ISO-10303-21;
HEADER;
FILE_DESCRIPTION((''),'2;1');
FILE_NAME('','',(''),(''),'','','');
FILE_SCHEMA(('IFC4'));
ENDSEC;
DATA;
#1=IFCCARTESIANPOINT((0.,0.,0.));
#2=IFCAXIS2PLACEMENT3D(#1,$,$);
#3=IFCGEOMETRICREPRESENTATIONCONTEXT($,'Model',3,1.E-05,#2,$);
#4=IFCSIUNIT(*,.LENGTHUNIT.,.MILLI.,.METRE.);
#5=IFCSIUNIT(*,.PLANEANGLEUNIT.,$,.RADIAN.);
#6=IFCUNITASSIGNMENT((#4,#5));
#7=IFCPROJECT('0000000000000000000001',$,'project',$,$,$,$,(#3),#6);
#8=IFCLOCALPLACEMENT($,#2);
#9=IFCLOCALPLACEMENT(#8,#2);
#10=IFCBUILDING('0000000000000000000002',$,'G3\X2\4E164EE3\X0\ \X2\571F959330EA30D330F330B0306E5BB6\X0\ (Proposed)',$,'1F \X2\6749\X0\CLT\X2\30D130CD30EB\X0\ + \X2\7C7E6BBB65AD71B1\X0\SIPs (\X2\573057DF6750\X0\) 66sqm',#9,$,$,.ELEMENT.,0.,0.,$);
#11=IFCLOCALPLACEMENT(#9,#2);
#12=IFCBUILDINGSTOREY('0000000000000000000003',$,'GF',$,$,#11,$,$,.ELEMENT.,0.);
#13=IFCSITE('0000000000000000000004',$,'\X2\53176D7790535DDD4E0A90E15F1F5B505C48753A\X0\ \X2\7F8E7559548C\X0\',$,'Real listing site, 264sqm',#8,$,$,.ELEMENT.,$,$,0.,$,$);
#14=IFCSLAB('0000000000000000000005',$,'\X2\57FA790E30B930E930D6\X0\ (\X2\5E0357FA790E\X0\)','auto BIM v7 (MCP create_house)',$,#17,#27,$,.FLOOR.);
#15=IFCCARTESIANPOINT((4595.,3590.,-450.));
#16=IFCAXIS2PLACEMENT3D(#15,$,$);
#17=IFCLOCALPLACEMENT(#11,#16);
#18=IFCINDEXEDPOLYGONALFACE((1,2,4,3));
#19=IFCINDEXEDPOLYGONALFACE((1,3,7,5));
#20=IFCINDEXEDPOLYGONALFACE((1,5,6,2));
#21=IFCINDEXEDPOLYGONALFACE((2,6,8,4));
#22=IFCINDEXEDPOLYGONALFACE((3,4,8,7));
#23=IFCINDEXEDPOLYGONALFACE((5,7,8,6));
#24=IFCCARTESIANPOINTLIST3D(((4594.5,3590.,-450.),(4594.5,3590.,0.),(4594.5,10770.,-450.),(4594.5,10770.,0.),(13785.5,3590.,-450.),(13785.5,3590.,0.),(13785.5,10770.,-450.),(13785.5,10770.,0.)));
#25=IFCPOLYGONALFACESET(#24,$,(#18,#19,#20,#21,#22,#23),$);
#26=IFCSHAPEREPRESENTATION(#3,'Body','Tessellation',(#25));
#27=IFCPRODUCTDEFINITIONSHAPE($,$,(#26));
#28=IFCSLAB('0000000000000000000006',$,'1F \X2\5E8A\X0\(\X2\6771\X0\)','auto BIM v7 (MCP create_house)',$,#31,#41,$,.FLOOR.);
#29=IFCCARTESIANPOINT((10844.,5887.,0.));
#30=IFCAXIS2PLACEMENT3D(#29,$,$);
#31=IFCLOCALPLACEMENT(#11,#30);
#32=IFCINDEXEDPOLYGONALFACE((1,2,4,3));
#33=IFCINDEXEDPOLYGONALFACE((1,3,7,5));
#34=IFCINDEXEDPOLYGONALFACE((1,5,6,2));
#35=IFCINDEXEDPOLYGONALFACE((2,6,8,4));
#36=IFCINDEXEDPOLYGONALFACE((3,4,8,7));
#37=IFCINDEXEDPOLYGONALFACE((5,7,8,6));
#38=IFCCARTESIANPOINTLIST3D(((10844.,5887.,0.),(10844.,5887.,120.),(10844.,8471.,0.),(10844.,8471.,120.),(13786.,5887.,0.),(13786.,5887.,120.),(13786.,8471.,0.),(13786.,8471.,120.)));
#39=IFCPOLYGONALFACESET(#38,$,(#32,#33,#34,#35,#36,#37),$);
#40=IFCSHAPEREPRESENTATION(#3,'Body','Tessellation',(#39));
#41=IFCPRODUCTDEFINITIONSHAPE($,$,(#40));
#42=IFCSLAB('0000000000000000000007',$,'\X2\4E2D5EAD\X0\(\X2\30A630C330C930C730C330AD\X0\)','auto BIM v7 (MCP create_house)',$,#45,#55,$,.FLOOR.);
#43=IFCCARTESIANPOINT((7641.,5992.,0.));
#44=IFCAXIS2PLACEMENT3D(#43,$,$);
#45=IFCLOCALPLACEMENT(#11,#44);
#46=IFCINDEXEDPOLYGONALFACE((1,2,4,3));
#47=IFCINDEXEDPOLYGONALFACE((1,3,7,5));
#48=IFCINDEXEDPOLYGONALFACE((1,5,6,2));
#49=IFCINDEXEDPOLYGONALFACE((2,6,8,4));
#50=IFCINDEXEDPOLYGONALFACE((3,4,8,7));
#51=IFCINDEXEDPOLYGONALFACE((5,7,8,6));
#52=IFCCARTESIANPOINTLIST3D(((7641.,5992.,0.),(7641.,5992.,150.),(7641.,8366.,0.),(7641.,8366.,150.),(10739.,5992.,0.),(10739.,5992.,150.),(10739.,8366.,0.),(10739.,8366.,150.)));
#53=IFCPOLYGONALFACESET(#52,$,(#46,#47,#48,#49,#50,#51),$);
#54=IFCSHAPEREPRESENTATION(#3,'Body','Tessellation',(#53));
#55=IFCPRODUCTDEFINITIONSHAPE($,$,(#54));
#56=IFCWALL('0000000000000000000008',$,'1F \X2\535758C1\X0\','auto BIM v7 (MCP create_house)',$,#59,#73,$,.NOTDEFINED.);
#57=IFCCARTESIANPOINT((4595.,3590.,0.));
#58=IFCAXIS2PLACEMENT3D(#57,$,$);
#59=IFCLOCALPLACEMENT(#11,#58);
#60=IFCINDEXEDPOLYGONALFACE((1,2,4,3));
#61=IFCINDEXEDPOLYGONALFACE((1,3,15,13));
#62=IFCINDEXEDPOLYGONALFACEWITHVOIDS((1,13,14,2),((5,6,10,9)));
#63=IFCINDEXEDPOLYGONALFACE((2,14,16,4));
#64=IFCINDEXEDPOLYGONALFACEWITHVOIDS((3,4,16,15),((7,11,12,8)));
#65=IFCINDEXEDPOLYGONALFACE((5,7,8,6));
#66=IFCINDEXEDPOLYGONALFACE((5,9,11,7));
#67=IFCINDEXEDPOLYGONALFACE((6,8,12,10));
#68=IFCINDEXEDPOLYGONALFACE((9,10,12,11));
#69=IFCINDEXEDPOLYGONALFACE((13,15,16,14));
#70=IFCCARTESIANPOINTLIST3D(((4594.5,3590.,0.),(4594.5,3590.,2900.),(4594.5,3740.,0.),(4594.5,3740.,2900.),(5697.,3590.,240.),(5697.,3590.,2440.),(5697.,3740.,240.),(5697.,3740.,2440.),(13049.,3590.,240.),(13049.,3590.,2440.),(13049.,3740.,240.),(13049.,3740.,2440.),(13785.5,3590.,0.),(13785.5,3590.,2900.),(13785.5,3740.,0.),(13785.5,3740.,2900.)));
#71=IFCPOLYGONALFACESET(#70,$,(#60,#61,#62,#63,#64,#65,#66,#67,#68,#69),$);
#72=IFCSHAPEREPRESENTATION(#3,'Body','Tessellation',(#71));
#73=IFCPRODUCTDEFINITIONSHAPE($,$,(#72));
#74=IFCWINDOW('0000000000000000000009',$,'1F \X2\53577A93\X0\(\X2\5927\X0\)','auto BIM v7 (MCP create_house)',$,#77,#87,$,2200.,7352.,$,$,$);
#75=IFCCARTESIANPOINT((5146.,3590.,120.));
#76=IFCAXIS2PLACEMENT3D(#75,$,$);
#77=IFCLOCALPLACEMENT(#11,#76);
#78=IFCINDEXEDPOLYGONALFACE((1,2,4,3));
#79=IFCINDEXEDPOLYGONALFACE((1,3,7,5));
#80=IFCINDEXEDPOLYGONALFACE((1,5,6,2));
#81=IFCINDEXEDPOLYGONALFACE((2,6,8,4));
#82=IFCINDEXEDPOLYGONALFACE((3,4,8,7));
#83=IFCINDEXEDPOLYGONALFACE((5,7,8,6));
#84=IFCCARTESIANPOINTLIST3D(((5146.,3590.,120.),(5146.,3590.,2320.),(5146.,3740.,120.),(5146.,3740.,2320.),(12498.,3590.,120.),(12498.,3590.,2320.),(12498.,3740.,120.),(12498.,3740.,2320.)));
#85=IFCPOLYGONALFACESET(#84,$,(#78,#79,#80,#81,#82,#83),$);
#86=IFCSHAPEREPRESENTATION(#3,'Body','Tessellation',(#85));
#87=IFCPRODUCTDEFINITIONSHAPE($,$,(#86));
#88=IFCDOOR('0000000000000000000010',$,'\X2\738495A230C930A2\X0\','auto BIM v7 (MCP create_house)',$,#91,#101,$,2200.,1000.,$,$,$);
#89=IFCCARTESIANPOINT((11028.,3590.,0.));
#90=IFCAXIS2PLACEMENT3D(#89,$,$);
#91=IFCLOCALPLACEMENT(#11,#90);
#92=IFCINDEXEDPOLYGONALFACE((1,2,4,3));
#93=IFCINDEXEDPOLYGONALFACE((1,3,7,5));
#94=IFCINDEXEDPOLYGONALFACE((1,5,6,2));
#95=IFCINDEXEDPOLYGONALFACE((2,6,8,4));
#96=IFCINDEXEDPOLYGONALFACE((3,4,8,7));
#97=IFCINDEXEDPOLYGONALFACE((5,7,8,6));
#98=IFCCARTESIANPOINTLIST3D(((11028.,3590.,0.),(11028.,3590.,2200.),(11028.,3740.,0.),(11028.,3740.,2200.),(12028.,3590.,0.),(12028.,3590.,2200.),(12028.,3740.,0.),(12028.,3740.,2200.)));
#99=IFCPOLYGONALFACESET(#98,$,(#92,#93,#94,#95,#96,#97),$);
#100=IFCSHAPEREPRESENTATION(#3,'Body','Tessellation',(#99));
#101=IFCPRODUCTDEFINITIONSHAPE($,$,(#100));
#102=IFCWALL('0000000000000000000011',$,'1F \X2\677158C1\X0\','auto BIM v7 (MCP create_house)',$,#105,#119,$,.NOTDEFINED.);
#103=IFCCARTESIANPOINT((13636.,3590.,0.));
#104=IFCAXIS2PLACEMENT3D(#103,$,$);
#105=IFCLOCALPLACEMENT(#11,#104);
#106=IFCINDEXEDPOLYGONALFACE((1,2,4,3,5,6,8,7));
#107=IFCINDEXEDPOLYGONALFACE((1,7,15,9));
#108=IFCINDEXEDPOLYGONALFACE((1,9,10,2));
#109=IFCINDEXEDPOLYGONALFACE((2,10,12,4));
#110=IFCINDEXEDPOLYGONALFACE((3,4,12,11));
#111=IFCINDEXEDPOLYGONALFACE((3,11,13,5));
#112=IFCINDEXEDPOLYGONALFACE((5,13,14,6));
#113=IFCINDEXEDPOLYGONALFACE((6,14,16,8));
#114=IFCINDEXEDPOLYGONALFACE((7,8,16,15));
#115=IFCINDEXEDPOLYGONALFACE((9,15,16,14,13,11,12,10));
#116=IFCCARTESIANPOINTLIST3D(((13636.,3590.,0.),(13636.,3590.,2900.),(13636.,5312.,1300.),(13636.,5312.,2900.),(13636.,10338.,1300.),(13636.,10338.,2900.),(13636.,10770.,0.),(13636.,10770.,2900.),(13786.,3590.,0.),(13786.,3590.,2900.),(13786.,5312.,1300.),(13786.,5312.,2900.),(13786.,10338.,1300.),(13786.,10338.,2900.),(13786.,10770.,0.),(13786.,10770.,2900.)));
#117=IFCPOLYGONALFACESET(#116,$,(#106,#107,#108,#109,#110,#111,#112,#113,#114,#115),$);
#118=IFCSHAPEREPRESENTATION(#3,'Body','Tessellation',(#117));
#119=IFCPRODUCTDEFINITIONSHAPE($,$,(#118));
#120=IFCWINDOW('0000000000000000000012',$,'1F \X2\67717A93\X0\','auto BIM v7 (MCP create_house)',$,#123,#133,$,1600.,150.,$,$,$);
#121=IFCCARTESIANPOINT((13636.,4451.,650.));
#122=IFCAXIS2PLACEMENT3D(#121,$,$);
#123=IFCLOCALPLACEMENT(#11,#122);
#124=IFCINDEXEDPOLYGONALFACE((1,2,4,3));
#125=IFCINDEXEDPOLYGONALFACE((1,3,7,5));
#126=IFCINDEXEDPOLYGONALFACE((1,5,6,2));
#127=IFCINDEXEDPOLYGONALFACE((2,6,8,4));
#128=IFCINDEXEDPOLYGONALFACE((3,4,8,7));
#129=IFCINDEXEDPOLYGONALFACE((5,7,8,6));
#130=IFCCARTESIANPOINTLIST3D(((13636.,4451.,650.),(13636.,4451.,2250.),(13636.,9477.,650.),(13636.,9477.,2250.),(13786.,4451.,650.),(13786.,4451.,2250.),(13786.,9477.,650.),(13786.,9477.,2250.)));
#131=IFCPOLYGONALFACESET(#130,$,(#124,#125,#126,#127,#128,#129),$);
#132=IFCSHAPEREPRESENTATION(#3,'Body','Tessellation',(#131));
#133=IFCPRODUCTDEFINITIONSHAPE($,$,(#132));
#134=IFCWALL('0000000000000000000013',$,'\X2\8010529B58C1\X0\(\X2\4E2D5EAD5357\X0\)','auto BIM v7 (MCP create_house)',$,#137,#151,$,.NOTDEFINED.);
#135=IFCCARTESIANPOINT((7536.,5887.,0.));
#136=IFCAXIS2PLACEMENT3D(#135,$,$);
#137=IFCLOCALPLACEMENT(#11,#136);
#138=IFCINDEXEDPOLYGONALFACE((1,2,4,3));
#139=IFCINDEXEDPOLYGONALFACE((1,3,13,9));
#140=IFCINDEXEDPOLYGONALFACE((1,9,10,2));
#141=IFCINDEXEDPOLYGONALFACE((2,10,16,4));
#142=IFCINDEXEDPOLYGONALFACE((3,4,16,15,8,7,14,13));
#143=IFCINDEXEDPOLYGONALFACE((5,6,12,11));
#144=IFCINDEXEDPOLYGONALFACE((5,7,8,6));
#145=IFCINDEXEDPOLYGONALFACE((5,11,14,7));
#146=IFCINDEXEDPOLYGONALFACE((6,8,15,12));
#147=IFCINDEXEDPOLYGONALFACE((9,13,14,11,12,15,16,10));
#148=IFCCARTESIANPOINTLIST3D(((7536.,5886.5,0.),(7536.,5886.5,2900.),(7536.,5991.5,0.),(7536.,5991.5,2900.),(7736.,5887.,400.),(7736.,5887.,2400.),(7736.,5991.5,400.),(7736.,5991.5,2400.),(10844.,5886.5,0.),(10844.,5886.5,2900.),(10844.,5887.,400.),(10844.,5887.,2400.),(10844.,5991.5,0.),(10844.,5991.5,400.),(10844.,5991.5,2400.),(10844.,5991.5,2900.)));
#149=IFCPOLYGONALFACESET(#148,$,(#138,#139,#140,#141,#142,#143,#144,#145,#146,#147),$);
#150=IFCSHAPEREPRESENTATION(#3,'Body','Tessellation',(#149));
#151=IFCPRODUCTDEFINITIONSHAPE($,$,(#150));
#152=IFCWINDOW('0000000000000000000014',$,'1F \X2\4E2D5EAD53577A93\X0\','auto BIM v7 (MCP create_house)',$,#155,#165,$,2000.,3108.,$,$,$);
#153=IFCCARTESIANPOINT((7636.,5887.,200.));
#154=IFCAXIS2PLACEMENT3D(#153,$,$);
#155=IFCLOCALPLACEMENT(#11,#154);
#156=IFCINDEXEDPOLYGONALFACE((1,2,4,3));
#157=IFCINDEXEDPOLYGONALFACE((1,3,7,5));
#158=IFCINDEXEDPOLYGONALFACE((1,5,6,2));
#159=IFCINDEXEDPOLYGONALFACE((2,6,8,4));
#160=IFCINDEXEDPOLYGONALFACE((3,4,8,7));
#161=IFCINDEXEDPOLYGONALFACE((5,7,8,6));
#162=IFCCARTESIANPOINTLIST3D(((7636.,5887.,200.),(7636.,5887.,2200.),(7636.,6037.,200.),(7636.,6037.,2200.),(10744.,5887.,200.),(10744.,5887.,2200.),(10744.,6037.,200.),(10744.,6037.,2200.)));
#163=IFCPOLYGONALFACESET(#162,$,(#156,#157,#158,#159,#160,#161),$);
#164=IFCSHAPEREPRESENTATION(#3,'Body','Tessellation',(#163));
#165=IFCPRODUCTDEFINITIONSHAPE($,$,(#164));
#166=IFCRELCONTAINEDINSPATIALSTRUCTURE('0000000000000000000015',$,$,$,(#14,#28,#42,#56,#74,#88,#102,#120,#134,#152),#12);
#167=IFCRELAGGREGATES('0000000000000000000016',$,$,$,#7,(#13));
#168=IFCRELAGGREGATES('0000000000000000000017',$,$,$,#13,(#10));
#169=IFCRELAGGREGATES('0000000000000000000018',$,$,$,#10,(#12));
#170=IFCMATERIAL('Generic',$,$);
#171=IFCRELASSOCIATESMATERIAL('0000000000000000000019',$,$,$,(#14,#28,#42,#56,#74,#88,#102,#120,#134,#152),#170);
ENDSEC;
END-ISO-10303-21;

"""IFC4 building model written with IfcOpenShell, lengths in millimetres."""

from ifc_helpers import new_model, si_unit, frame, frame_2d, origin, place, context, project, spatial, rectangle, extrude, material, element, fill, save


model = new_model("IFC4")

# Units and contexts
model_context = context("Model", 3, precision=1e-05, world=origin())
ifc_project = project(units=[si_unit("LENGTHUNIT", "METRE", prefix="MILLI"), si_unit("PLANEANGLEUNIT", "RADIAN")], contexts=[model_context])

# Site, building, storey
site_placement = place(None, origin())
site = spatial("IfcSite", under=ifc_project, at=site_placement, Name="北海道川上郡弟子屈町 美留和", ObjectType="Real listing site, 264sqm", CompositionType="ELEMENT", RefElevation=0.0)
building_placement = place(site_placement, origin())
building = spatial("IfcBuilding", under=site, at=building_placement, Name="G3世代 土間リビングの家 (Proposed)", ObjectType="1F 杉CLTパネル + 籾殻断熱SIPs (地域材) 66sqm", CompositionType="ELEMENT", ElevationOfRefHeight=0.0, ElevationOfTerrain=0.0)
storey_placement = place(building_placement, origin())
storey = spatial("IfcBuildingStorey", under=building, at=storey_placement, Name="GF", CompositionType="ELEMENT", Elevation=0.0)

# Slabs
ifc_material = material(Name="Generic")
slab_1_placement = place(storey_placement, frame((4595.0, 3590.0, -450.0)))
element("IfcSlab", 1, at=slab_1_placement, inside=storey, material=ifc_material, Name="基礎スラブ (布基礎)", Description="auto BIM v7 (MCP create_house)", PredefinedType="FLOOR", context=model_context, shape_type="SweptSolid", body=[
    extrude(rectangle(XDim=9191.0, YDim=7180.0, at=frame_2d((4595.0, 3590.0))), frame((4595.0, 3590.0, -450.0)), (0.0, 0.0, 1.0), 450.0),
])
slab_2_placement = place(storey_placement, frame((10844.0, 5887.0, 0.0)))
element("IfcSlab", 2, at=slab_2_placement, inside=storey, material=ifc_material, Name="1F 床(東)", Description="auto BIM v7 (MCP create_house)", PredefinedType="FLOOR", context=model_context, shape_type="SweptSolid", body=[
    extrude(rectangle(XDim=2942.0, YDim=2584.0, at=frame_2d((1471.0, 1292.0))), frame((10844.0, 5887.0, 0.0)), (0.0, 0.0, 1.0), 120.0),
])
slab_3_placement = place(storey_placement, frame((7641.0, 5992.0, 0.0)))
element("IfcSlab", 3, at=slab_3_placement, inside=storey, material=ifc_material, Name="中庭(ウッドデッキ)", Description="auto BIM v7 (MCP create_house)", PredefinedType="FLOOR", context=model_context, shape_type="SweptSolid", body=[
    extrude(rectangle(XDim=3098.0, YDim=2374.0, at=frame_2d((1549.0, 1187.0))), frame((7641.0, 5992.0, 0.0)), (0.0, 0.0, 1.0), 150.0),
])

# Wall, openings, window, door
wall_1_placement = place(storey_placement, frame((4595.0, 3590.0, 0.0)))
wall_1 = element("IfcWall", 4, at=wall_1_placement, inside=storey, material=ifc_material, Name="1F 南壁", Description="auto BIM v7 (MCP create_house)", PredefinedType="NOTDEFINED", context=model_context, shape_type="SweptSolid", body=[
    extrude(rectangle(XDim=9191.0, YDim=150.0, at=frame_2d((4595.0, 75.0))), frame((4595.0, 3590.0, 0.0)), (0.0, 0.0, 1.0), 2900.0),
])
opening_1_placement = place(storey_placement, frame((5146.0, 3590.0, 120.0)))
opening_1 = element("IfcOpeningElement", 5, at=opening_1_placement, cuts=wall_1, PredefinedType="NOTDEFINED", context=model_context, shape_type="SweptSolid", body=[
    extrude(rectangle(XDim=7352.0, YDim=150.0, at=frame_2d((3676.0, 75.0))), frame((5146.0, 3590.0, 120.0)), (0.0, 0.0, 1.0), 2200.0),
])
opening_2_placement = place(storey_placement, frame((11028.0, 3590.0, 0.0)))
opening_2 = element("IfcOpeningElement", 6, at=opening_2_placement, cuts=wall_1, PredefinedType="NOTDEFINED", context=model_context, shape_type="SweptSolid", body=[
    extrude(rectangle(XDim=1000.0, YDim=150.0, at=frame_2d((500.0, 75.0))), frame((11028.0, 3590.0, 0.0)), (0.0, 0.0, 1.0), 2200.0),
])
window_1_placement = place(storey_placement, frame((5146.0, 3590.0, 120.0)))
window_1 = element("IfcWindow", 7, at=window_1_placement, inside=storey, material=ifc_material, Name="1F 南窓(大)", Description="auto BIM v7 (MCP create_house)", OverallHeight=2200.0, OverallWidth=7352.0, context=model_context, shape_type="SweptSolid", body=[
    extrude(rectangle(XDim=7352.0, YDim=150.0, at=frame_2d((3676.0, 75.0))), frame((5146.0, 3590.0, 120.0)), (0.0, 0.0, 1.0), 2200.0),
])
fill(opening_1, window_1)
door_placement = place(storey_placement, frame((11028.0, 3590.0, 0.0)))
door = element("IfcDoor", 8, at=door_placement, inside=storey, material=ifc_material, Name="玄関ドア", Description="auto BIM v7 (MCP create_house)", OverallHeight=2200.0, OverallWidth=1000.0, context=model_context, shape_type="SweptSolid", body=[
    extrude(rectangle(XDim=1000.0, YDim=150.0, at=frame_2d((500.0, 75.0))), frame((11028.0, 3590.0, 0.0)), (0.0, 0.0, 1.0), 2200.0),
])
fill(opening_2, door)

# Walls, openings, windows
wall_2_placement = place(storey_placement, frame((13636.0, 3590.0, 0.0)))
wall_2 = element("IfcWall", 9, at=wall_2_placement, inside=storey, material=ifc_material, Name="1F 東壁", Description="auto BIM v7 (MCP create_house)", PredefinedType="NOTDEFINED", context=model_context, shape_type="SweptSolid", body=[
    extrude(rectangle(XDim=150.0, YDim=7180.0, at=frame_2d((75.0, 3590.0))), frame((13636.0, 3590.0, 0.0)), (0.0, 0.0, 1.0), 2900.0),
])
opening_3_placement = place(storey_placement, frame((13636.0, 4451.0, 650.0)))
opening_3 = element("IfcOpeningElement", 10, at=opening_3_placement, cuts=wall_2, PredefinedType="NOTDEFINED", context=model_context, shape_type="SweptSolid", body=[
    extrude(rectangle(XDim=150.0, YDim=5026.0, at=frame_2d((75.0, 2513.0))), frame((13636.0, 4451.0, 650.0)), (0.0, 0.0, 1.0), 1600.0),
])
window_2_placement = place(storey_placement, frame((13636.0, 4451.0, 650.0)))
window_2 = element("IfcWindow", 11, at=window_2_placement, inside=storey, material=ifc_material, Name="1F 東窓", Description="auto BIM v7 (MCP create_house)", OverallHeight=1600.0, OverallWidth=150.0, context=model_context, shape_type="SweptSolid", body=[
    extrude(rectangle(XDim=150.0, YDim=5026.0, at=frame_2d((75.0, 2513.0))), frame((13636.0, 4451.0, 650.0)), (0.0, 0.0, 1.0), 1600.0),
])
fill(opening_3, window_2)
wall_3_placement = place(storey_placement, frame((7536.0, 5887.0, 0.0)))
wall_3 = element("IfcWall", 12, at=wall_3_placement, inside=storey, material=ifc_material, Name="耐力壁(中庭南)", Description="auto BIM v7 (MCP create_house)", PredefinedType="NOTDEFINED", context=model_context, shape_type="SweptSolid", body=[
    extrude(rectangle(XDim=3308.0, YDim=105.0, at=frame_2d((1654.0, 52.0))), frame((7536.0, 5887.0, 0.0)), (0.0, 0.0, 1.0), 2900.0),
])
opening_4_placement = place(storey_placement, frame((7636.0, 5887.0, 200.0)))
opening_4 = element("IfcOpeningElement", 13, at=opening_4_placement, cuts=wall_3, PredefinedType="NOTDEFINED", context=model_context, shape_type="SweptSolid", body=[
    extrude(rectangle(XDim=3108.0, YDim=150.0, at=frame_2d((1554.0, 75.0))), frame((7636.0, 5887.0, 200.0)), (0.0, 0.0, 1.0), 2000.0),
])
window_3_placement = place(storey_placement, frame((7636.0, 5887.0, 200.0)))
window_3 = element("IfcWindow", 14, at=window_3_placement, inside=storey, material=ifc_material, Name="1F 中庭南窓", Description="auto BIM v7 (MCP create_house)", OverallHeight=2000.0, OverallWidth=3108.0, context=model_context, shape_type="SweptSolid", body=[
    extrude(rectangle(XDim=3108.0, YDim=150.0, at=frame_2d((1554.0, 75.0))), frame((7636.0, 5887.0, 200.0)), (0.0, 0.0, 1.0), 2000.0),
])
fill(opening_4, window_3)

save(model, "model.ifc")
